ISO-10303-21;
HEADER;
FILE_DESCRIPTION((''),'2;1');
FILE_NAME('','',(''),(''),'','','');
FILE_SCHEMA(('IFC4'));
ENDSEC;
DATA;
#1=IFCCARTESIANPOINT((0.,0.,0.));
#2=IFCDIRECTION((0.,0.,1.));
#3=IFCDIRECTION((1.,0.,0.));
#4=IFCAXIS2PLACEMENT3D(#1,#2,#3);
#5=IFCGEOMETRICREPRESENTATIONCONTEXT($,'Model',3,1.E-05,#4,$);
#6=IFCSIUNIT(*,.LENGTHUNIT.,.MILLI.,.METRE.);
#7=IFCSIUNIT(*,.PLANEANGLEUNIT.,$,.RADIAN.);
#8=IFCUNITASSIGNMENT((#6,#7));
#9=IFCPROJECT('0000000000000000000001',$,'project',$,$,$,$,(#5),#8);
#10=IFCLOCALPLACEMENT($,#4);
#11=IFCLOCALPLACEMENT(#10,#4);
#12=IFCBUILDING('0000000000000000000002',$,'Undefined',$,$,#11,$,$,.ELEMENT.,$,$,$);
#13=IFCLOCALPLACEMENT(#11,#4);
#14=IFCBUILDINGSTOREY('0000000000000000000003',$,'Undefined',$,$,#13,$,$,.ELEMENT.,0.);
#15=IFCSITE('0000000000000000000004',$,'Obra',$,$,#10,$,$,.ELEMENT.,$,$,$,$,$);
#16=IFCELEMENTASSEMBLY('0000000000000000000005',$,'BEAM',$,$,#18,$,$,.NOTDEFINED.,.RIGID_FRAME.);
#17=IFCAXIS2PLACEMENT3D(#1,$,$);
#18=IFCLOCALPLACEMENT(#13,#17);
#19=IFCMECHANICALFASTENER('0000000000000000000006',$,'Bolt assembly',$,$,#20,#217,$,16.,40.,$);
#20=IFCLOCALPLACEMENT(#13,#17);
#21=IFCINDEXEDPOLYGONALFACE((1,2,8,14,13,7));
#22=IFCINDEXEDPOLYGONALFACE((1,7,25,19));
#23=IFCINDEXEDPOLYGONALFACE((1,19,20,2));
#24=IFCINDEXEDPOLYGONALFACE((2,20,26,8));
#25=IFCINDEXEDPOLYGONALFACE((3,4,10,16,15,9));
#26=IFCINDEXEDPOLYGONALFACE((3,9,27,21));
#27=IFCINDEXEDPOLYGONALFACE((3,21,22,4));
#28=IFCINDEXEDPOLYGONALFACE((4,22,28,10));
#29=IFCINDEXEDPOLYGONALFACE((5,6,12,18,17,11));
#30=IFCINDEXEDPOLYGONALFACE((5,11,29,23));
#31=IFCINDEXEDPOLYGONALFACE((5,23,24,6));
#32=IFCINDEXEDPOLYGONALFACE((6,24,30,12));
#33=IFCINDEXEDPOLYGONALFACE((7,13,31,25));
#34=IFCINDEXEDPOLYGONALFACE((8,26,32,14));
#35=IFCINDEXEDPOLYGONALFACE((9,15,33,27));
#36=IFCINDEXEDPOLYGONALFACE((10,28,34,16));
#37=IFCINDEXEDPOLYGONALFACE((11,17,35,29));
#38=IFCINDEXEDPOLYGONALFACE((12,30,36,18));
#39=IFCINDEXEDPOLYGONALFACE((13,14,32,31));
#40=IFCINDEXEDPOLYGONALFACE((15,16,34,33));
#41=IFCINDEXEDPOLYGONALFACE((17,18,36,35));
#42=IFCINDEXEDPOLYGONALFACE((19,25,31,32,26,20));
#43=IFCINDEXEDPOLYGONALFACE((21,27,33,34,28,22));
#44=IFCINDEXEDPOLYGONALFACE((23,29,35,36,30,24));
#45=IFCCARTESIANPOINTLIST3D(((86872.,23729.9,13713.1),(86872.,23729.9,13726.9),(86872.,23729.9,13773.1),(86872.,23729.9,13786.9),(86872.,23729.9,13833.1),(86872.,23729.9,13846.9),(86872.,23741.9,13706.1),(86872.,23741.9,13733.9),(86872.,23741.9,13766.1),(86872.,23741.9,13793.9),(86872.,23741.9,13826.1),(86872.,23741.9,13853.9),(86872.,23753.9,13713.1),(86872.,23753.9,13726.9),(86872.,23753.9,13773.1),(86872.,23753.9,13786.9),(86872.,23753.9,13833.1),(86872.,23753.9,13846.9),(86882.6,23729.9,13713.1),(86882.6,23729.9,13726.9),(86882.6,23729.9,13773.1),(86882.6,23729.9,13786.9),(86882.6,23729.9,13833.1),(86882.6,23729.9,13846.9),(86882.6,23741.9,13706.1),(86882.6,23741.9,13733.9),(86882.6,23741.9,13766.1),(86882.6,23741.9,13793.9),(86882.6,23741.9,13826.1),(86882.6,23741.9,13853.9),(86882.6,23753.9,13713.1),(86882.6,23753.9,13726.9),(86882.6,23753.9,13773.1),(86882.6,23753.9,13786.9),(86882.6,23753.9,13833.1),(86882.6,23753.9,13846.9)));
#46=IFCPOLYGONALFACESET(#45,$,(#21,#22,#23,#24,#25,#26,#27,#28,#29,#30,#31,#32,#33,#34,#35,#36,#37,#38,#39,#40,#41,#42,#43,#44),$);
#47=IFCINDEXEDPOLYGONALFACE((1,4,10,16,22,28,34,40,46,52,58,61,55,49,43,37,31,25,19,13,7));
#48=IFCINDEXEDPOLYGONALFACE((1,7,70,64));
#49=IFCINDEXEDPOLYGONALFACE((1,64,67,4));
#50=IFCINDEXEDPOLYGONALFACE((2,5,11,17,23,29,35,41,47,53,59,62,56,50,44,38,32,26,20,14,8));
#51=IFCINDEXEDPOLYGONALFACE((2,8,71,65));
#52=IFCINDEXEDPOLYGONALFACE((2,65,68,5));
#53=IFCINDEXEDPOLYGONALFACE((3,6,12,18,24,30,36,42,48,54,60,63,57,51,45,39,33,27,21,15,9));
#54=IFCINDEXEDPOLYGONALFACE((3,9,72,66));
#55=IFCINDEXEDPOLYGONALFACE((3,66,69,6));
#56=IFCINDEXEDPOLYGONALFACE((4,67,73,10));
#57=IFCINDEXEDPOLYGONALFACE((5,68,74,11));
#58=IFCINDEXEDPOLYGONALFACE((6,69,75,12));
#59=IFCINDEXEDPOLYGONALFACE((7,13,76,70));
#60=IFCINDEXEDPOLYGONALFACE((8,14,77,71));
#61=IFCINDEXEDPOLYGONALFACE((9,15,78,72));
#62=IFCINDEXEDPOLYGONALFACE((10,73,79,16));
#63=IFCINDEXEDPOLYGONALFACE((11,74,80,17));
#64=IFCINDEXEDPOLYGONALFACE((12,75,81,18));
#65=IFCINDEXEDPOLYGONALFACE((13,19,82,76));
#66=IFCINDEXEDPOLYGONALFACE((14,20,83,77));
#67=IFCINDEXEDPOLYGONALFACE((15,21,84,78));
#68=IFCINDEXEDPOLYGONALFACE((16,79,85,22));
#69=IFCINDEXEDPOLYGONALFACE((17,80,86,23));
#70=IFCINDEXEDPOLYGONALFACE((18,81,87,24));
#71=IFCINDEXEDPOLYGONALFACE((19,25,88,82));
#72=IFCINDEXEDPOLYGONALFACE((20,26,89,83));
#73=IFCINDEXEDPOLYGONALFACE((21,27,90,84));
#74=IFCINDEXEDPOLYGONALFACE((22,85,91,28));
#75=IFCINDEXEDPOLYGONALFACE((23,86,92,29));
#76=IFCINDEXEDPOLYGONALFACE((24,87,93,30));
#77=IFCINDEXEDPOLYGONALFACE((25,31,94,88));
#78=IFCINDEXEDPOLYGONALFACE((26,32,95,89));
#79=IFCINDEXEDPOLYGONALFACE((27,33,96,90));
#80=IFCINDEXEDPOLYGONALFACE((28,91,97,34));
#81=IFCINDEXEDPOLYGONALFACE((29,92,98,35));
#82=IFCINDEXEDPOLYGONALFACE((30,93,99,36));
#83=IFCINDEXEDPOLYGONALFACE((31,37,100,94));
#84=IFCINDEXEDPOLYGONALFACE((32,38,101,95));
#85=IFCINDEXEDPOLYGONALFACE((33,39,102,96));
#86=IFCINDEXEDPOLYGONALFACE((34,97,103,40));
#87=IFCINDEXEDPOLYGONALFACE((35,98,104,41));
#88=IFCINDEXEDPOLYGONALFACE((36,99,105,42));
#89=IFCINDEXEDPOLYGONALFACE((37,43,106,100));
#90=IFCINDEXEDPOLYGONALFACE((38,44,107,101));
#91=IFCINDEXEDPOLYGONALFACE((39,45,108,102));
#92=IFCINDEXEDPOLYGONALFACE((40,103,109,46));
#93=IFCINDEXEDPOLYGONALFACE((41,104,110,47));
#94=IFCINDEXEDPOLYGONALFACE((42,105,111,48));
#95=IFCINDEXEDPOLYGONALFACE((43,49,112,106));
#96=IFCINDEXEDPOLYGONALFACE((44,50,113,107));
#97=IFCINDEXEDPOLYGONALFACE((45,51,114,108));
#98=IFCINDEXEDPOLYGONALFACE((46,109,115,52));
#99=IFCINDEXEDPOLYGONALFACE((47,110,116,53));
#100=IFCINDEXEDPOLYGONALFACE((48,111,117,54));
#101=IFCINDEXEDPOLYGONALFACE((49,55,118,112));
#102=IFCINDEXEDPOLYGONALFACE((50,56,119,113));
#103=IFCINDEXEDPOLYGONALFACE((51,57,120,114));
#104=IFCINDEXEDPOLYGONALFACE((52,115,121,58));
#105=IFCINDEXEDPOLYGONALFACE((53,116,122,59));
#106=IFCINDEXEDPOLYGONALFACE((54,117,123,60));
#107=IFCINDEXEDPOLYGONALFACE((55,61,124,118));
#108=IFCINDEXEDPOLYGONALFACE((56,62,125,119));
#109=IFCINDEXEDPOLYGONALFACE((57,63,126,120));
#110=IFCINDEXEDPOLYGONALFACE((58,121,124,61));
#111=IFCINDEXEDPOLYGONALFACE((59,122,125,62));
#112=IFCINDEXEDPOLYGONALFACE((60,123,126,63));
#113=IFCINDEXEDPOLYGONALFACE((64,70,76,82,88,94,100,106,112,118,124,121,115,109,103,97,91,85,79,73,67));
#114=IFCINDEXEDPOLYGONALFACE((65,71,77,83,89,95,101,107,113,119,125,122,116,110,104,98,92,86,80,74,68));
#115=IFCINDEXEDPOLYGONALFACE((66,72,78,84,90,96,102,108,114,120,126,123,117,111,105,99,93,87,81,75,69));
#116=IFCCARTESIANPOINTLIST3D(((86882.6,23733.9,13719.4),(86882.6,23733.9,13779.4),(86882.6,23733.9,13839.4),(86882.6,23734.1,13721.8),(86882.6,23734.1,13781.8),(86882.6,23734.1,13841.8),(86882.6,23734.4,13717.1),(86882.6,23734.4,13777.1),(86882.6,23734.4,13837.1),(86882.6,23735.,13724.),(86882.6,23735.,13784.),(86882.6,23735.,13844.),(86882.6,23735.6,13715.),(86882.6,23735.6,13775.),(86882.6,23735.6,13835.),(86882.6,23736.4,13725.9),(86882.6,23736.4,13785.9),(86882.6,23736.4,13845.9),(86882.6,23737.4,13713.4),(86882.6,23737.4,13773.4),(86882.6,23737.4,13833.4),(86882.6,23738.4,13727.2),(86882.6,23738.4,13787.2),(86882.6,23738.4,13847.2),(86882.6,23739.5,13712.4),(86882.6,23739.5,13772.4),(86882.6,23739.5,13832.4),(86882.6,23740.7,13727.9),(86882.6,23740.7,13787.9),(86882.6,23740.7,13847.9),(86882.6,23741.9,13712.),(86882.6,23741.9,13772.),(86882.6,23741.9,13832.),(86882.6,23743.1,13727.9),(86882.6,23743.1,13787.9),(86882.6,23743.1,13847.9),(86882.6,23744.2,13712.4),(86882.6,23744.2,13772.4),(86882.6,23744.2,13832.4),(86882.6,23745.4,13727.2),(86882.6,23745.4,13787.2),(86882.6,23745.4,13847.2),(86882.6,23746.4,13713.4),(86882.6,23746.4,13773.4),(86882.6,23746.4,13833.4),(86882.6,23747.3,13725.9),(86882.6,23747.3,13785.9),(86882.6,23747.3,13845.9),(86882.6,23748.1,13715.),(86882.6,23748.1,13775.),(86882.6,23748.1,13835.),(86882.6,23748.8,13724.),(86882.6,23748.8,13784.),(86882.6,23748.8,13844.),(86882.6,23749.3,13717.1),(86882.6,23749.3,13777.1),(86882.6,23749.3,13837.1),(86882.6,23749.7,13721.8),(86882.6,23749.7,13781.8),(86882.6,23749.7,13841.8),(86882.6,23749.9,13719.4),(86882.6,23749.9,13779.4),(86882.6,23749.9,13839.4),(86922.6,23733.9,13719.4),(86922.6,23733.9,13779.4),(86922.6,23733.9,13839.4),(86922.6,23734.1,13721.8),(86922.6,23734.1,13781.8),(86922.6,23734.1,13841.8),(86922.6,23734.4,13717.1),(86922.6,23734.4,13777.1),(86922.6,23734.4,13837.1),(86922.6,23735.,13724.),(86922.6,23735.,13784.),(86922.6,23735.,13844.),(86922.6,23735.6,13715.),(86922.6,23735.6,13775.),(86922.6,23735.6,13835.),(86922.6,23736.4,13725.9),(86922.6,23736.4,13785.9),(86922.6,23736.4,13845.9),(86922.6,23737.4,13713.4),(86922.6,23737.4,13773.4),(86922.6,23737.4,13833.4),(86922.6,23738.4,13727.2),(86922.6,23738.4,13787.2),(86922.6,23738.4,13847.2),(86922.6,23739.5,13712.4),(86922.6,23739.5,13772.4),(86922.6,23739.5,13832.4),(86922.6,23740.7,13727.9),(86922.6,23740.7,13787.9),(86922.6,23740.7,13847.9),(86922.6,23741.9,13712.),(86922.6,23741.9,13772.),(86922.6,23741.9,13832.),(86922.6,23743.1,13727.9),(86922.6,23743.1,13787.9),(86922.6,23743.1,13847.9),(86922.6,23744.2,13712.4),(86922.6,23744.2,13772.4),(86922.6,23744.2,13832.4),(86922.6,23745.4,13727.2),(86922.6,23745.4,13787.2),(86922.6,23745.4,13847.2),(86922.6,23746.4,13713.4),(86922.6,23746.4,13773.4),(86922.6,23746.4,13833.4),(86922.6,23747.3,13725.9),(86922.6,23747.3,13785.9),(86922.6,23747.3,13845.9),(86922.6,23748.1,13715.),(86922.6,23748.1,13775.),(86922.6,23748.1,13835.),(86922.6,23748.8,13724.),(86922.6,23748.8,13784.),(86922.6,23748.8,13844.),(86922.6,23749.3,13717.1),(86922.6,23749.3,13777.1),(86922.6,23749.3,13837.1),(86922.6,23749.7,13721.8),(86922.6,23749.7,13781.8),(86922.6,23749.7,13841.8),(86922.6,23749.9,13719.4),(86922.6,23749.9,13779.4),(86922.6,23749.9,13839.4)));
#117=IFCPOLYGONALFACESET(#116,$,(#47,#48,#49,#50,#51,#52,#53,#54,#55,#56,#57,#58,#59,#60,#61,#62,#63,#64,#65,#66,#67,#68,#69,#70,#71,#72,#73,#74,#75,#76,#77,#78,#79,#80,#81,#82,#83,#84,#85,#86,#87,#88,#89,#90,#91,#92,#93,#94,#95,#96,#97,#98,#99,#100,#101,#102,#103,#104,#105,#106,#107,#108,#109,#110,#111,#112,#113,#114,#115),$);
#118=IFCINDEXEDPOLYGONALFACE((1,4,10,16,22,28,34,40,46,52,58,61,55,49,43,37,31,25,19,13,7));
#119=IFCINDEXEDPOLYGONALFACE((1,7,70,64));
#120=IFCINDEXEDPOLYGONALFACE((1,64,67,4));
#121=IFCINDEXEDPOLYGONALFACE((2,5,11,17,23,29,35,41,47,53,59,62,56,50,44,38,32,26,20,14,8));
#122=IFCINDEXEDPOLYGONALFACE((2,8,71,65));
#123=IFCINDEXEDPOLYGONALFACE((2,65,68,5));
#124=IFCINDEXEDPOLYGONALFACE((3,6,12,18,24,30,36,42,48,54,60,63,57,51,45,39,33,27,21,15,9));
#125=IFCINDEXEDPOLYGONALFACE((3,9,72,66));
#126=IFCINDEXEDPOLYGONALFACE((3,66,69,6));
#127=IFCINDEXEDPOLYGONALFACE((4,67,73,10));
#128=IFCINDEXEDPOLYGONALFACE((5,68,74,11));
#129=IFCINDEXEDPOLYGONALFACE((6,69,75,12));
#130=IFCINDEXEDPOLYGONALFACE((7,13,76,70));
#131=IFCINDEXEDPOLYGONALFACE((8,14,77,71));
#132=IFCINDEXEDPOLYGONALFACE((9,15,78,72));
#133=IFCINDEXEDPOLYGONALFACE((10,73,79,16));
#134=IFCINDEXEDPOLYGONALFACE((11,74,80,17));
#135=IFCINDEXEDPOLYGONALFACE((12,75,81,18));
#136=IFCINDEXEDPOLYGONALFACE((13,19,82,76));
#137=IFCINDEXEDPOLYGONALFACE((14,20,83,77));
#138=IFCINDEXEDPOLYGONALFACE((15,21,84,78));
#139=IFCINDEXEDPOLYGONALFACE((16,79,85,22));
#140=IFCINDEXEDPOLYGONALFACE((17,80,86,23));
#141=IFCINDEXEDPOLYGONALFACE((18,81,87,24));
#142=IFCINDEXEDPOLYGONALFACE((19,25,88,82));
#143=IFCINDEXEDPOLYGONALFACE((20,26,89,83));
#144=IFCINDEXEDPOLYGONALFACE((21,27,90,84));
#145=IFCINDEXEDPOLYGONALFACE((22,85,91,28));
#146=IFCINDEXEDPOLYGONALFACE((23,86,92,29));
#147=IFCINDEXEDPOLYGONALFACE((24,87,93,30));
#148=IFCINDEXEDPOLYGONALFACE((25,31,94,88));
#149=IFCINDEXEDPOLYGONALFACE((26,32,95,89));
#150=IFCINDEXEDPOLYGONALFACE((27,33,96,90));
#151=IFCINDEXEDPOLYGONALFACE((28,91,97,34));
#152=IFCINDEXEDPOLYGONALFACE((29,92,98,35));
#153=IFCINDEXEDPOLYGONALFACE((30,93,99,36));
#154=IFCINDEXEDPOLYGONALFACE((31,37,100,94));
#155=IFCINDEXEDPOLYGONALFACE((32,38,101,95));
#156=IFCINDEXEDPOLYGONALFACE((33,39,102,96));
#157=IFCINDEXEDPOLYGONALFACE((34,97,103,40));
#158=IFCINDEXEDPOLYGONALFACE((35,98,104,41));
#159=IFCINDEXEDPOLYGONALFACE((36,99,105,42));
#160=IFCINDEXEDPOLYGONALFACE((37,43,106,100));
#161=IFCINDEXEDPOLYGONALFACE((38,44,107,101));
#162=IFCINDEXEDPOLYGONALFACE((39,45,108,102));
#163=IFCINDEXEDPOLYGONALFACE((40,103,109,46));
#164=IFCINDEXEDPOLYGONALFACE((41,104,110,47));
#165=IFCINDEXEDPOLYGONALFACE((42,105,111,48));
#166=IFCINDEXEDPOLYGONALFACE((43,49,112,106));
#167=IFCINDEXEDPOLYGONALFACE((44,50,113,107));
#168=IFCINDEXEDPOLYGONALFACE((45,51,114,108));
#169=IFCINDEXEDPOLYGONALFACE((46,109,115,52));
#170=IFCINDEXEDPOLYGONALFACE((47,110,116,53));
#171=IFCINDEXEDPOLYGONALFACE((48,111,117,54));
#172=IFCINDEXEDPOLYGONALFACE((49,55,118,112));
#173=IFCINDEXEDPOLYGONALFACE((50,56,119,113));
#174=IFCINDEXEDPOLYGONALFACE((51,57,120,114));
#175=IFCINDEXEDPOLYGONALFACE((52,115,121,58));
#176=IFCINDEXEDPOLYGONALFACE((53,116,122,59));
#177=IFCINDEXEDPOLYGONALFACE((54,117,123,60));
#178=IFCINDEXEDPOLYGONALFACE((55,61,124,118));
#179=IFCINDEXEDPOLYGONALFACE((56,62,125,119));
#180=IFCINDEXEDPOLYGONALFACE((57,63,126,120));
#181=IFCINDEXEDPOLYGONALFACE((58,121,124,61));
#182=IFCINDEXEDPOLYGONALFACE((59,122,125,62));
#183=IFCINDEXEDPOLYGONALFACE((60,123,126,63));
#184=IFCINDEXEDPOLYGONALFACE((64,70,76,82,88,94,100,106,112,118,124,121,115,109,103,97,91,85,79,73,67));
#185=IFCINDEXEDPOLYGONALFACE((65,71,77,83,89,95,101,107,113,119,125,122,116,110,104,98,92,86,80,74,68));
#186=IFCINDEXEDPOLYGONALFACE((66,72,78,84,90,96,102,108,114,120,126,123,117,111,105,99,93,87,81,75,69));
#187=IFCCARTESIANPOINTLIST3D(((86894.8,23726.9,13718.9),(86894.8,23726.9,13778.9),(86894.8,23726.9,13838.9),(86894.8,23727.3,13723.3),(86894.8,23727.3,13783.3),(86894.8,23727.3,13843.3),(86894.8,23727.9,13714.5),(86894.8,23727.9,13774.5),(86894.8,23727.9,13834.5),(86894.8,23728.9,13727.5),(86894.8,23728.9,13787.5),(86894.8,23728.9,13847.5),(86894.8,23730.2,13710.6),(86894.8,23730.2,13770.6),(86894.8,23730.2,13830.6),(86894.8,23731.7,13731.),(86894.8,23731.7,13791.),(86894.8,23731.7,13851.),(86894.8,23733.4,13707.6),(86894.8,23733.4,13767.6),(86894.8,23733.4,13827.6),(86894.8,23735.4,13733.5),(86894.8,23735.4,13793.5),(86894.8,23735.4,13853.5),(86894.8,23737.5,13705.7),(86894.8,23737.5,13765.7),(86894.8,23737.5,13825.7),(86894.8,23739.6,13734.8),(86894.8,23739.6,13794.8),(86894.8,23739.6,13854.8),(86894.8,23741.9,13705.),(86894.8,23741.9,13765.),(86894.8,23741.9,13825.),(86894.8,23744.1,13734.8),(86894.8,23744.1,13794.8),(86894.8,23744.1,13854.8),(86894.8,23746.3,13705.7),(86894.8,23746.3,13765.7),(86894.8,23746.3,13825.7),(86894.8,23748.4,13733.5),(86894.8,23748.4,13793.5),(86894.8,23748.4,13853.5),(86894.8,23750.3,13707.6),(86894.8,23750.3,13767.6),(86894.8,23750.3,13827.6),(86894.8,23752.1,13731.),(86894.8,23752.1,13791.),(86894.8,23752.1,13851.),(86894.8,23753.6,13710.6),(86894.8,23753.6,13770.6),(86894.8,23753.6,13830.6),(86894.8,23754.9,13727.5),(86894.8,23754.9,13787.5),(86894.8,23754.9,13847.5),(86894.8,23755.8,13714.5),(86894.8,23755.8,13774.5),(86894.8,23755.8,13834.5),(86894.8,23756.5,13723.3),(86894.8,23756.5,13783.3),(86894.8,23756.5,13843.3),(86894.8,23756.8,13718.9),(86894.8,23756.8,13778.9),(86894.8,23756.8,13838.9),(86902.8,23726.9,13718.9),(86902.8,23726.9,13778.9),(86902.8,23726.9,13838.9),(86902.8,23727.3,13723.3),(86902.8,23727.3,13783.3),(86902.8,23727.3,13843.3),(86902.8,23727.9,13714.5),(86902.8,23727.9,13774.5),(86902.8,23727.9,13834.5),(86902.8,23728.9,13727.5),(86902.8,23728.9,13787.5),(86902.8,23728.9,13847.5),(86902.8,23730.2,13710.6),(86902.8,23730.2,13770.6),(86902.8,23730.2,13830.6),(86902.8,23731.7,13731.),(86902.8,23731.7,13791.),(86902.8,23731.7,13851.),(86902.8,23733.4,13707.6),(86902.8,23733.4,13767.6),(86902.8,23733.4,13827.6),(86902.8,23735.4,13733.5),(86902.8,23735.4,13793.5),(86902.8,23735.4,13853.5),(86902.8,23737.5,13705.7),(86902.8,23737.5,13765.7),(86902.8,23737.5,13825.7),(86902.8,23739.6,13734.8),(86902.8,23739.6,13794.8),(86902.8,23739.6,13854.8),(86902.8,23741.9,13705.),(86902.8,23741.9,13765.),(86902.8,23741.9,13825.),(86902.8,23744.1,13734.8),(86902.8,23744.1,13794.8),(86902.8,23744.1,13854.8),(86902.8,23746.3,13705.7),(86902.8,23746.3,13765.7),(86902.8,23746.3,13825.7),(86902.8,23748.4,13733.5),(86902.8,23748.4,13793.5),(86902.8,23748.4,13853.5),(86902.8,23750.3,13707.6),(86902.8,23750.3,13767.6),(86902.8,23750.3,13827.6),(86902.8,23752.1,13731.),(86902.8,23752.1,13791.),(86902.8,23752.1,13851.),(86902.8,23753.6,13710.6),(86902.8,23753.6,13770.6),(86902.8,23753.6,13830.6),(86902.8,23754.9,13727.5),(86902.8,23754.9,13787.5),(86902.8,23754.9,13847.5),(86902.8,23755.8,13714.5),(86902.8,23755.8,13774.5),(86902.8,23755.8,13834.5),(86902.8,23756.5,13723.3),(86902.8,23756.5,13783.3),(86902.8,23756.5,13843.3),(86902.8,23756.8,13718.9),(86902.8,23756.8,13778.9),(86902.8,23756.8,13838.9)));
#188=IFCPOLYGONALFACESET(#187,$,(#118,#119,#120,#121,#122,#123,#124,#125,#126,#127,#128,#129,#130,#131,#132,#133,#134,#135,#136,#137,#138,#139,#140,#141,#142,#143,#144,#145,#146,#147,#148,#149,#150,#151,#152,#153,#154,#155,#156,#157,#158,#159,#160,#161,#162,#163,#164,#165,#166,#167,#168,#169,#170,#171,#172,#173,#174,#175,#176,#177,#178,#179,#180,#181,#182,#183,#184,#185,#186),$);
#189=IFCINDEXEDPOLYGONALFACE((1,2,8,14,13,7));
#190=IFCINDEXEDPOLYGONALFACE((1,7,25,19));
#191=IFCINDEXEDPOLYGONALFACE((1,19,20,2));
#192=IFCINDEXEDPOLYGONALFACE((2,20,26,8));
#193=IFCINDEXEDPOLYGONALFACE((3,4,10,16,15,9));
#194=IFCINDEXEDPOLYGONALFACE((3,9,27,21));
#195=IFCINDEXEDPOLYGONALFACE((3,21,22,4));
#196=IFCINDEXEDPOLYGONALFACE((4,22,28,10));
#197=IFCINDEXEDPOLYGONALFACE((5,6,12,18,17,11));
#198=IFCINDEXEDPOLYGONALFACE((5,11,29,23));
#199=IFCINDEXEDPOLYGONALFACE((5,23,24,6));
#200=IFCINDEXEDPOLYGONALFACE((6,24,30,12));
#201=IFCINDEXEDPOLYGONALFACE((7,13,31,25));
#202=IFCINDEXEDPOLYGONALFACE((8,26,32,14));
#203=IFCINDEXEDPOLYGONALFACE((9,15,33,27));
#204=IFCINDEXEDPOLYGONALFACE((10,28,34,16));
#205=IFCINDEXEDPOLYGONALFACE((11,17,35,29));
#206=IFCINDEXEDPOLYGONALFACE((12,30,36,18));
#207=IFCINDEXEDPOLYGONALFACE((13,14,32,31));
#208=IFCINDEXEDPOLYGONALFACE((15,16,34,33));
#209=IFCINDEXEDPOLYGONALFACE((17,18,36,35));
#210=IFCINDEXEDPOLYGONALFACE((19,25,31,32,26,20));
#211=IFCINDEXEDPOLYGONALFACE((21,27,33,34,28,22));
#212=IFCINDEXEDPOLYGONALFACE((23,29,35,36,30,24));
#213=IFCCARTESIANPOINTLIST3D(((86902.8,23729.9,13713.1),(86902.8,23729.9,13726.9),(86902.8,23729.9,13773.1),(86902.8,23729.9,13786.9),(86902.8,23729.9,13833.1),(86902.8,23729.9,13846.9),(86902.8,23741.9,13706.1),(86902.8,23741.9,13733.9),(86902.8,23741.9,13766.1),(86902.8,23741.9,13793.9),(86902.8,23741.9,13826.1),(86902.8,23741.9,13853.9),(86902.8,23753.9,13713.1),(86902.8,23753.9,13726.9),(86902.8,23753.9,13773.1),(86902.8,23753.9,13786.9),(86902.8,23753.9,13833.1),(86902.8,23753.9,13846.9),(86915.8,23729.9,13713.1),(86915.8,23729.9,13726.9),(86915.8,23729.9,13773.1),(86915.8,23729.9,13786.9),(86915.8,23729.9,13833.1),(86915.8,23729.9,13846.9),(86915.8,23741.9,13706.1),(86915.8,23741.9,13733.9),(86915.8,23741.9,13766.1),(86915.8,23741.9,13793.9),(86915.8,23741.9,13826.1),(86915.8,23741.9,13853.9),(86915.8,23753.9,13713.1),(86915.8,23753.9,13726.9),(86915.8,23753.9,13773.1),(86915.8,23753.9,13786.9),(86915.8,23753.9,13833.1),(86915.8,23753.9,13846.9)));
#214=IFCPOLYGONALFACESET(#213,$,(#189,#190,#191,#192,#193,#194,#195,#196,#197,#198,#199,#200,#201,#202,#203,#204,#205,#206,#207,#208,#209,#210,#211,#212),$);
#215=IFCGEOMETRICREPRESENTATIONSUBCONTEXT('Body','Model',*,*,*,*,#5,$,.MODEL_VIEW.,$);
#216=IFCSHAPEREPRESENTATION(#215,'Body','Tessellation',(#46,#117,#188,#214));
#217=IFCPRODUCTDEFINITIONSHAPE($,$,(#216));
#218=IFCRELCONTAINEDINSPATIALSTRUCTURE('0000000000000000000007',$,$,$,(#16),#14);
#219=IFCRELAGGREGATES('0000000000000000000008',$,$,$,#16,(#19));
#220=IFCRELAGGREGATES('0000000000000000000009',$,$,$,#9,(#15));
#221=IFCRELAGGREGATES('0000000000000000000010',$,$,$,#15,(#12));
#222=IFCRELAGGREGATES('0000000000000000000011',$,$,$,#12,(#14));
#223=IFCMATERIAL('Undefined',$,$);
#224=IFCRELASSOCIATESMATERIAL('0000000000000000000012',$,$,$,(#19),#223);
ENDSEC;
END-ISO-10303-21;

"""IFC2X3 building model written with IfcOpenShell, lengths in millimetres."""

from ifc_helpers import new_model, si_unit, frame, origin_with_axes, origin_2d_with_axis, place, context, subcontext, project, spatial, polyline, circle, outline, extrude, source, transform, mapped, material, element, aggregate, save


model = new_model("IFC2X3")

# Units and contexts
model_context = context("Model", 3, precision=1e-05, world=origin_with_axes())
body_context = subcontext(model_context, "Body", "Model", "MODEL_VIEW")
ifc_project = project(units=[si_unit("LENGTHUNIT", "METRE", prefix="MILLI"), si_unit("PLANEANGLEUNIT", "RADIAN")], contexts=[model_context])

# Site, building, storey
site_placement = place(None, origin_with_axes())
site = spatial("IfcSite", under=ifc_project, at=site_placement, Name="Obra", CompositionType="ELEMENT")
building_placement = place(site_placement, origin_with_axes())
building = spatial("IfcBuilding", under=site, at=building_placement, Name="Undefined", CompositionType="ELEMENT")
storey_placement = place(building_placement, origin_with_axes())
storey = spatial("IfcBuildingStorey", under=building, at=storey_placement, Name="Undefined", CompositionType="ELEMENT", Elevation=0.0)

# Shared definitions
ifc_material_1 = material(Name="Undefined")
shared_shape_1 = source(origin_with_axes(), body_context, "Body", "SweptSolid", [
    extrude(outline(polyline([(13.9, 0.0), (6.9, 12.0), (-6.9, 12.0), (-13.9, 0.0), (-6.9, -12.0), (6.9, -12.0), (13.9, 0.0)])), frame((0.0, -19.7, 0.0), z_axis=(0.0, 1.0, 0.0), x_axis=(1.0, 0.0, 0.0)), (0.0, 0.0, 1.0), 10.6),
    extrude(circle(Radius=8.0, at=origin_2d_with_axis()), frame((0.0, -9.1, 0.0), z_axis=(0.0, 1.0, 0.0), x_axis=(1.0, 0.0, 0.0)), (0.0, 0.0, 1.0), 40.0),
    extrude(circle(Radius=15.0, at=origin_2d_with_axis()), frame((0.0, 3.1, 0.0), z_axis=(0.0, 1.0, 0.0), x_axis=(1.0, 0.0, 0.0)), (0.0, 0.0, 1.0), 8.0),
    extrude(outline(polyline([(13.9, 0.0), (6.9, 12.0), (-6.9, 12.0), (-13.9, 0.0), (-6.9, -12.0), (6.9, -12.0), (13.9, 0.0)])), frame((0.0, 11.1, 0.0), z_axis=(0.0, 1.0, 0.0), x_axis=(1.0, 0.0, 0.0)), (0.0, 0.0, 1.0), 13.0),
])

# Element assembly, mechanical fastener
assembly_1_placement = place(storey_placement, origin_with_axes())
assembly_1 = element("IfcElementAssembly", 1, at=assembly_1_placement, inside=storey, Name="BEAM", AssemblyPlace="NOTDEFINED", PredefinedType="RIGID_FRAME")
mechanical_fastener_1_placement = place(assembly_1_placement, frame((86891.7, 23791.9, 13885.4), z_axis=(0.0, -1.0, 0.0), x_axis=(0.0, 0.0, -1.0)))
mechanical_fastener_1 = element("IfcMechanicalFastener", 2, at=mechanical_fastener_1_placement, material=ifc_material_1, Name="Bolt assembly", NominalDiameter=16.0, NominalLength=40.0, context=body_context, shape_type="MappedRepresentation", body=[
    mapped(shared_shape_1, transform((165.4, 0.0, 50.0))),
    mapped(shared_shape_1, transform((105.4, 0.0, 50.0))),
    mapped(shared_shape_1, transform((45.4, 0.0, 50.0))),
])
aggregate(assembly_1, [mechanical_fastener_1])

save(model, "model.ifc")
